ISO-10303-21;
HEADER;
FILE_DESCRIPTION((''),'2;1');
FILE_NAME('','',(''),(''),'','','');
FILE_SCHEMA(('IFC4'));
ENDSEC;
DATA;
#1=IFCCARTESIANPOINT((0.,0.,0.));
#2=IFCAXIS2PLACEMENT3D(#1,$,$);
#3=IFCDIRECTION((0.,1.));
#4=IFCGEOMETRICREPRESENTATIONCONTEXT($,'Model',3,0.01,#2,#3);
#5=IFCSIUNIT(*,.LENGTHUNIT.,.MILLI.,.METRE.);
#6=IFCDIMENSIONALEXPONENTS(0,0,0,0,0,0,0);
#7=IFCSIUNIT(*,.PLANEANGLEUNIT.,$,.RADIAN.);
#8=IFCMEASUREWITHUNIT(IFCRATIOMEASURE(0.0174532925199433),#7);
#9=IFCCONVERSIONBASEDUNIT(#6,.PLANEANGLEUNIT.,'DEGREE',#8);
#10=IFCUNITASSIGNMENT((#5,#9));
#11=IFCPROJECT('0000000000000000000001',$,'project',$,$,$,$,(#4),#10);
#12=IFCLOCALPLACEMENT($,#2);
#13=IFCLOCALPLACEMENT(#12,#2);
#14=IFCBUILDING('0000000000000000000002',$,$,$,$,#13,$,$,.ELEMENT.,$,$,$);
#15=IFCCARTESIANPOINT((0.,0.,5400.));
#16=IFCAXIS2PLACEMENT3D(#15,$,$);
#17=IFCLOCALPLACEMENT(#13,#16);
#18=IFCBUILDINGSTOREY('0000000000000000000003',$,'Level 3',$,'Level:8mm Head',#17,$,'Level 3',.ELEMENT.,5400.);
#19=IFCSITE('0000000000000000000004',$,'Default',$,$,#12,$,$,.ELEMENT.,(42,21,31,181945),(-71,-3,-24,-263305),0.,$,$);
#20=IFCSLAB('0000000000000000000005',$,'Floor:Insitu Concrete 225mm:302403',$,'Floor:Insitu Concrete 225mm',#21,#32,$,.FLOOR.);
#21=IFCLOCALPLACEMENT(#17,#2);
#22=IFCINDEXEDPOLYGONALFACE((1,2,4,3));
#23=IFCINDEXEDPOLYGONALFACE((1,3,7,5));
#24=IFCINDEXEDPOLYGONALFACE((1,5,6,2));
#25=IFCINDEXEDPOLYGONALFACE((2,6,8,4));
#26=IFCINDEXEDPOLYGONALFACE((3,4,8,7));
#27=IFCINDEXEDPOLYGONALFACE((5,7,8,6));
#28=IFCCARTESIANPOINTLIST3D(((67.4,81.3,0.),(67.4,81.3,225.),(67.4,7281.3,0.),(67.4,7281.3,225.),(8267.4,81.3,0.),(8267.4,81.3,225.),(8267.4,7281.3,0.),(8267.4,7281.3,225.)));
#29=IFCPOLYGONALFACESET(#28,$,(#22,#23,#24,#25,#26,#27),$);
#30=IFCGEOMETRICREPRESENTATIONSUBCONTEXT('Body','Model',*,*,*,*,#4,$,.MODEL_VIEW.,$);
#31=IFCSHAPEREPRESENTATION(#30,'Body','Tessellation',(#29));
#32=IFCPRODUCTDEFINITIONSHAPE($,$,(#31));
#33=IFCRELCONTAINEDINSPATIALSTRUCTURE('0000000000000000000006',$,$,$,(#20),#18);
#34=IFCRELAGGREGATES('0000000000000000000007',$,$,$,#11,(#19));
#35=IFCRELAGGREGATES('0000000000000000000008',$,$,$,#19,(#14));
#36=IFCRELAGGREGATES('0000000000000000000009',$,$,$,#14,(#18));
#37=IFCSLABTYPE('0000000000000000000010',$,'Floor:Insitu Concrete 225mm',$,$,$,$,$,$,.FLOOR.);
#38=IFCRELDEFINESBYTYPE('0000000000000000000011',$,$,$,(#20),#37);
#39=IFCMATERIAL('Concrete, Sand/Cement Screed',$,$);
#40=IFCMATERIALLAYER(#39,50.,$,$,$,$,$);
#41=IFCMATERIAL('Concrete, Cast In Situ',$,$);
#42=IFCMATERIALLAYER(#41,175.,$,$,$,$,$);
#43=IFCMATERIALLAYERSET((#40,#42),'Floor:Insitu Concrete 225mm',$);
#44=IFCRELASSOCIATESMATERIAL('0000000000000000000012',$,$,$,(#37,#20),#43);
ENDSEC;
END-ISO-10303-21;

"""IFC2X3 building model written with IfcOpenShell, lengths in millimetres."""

from ifc_helpers import new_model, entity, si_unit, converted_unit, direction, frame, frame_2d, origin, place, context, subcontext, project, spatial, rectangle, extrude, material, layer, layer_set, layer_usage, type_object, element, save


model = new_model("IFC2X3")

# Units and contexts
model_context = context("Model", 3, precision=0.01, world=origin(), true_north=direction((0.0, 1.0)))
body_context = subcontext(model_context, "Body", "Model", "MODEL_VIEW")
ifc_project = project(units=[si_unit("LENGTHUNIT", "METRE", prefix="MILLI"), converted_unit("PLANEANGLEUNIT", "DEGREE", entity("IfcRatioMeasure", 0.0174532925199433), si_unit("PLANEANGLEUNIT", "RADIAN"), dimensions=[0, 0, 0, 0, 0, 0, 0])], contexts=[model_context])

# Site, building, storey
site_placement = place(None, origin())
site = spatial("IfcSite", under=ifc_project, at=site_placement, Name="Default", CompositionType="ELEMENT", RefLatitude=(42, 21, 31, 181945), RefLongitude=(-71, -3, -24, -263305), RefElevation=0.0)
building_placement = place(site_placement, origin())
building = spatial("IfcBuilding", under=site, at=building_placement, CompositionType="ELEMENT")
storey_placement = place(building_placement, frame((0.0, 0.0, 5400.0)))
storey = spatial("IfcBuildingStorey", under=building, at=storey_placement, Name="Level 3", ObjectType="Level:8mm Head", LongName="Level 3", CompositionType="ELEMENT", Elevation=5400.0)

# Slab
ifc_material_1 = material(Name="Concrete, Sand/Cement Screed")
ifc_layer_1 = layer(ifc_material_1, 50.0)
ifc_material_2 = material(Name="Concrete, Cast In Situ")
ifc_layer_2 = layer(ifc_material_2, 175.0)
ifc_layer_set = layer_set([ifc_layer_1, ifc_layer_2], Name="Floor:Insitu Concrete 225mm")
ifc_layer_usage = layer_usage(ifc_layer_set, "AXIS3", "POSITIVE", 0.0)
slab_type = type_object("IfcSlabType", Name="Floor:Insitu Concrete 225mm", PredefinedType="FLOOR", material=ifc_layer_set)
slab_placement = place(storey_placement, origin())
element("IfcSlab", 1, at=slab_placement, inside=storey, type_object=slab_type, material=ifc_layer_usage, Name="Floor:Insitu Concrete 225mm:302403", ObjectType="Floor:Insitu Concrete 225mm", PredefinedType="FLOOR", context=body_context, shape_type="SweptSolid", body=[
    extrude(rectangle(XDim=7200.0, YDim=8200.0, at=frame_2d((0.0, 0.0), x_axis=(1.0, 0.0))), frame((4167.4, 3681.3, 225.0), z_axis=(0.0, 0.0, -1.0), x_axis=(0.0, 1.0, 0.0)), (0.0, 0.0, 1.0), 225.0),
])

save(model, "model.ifc")
